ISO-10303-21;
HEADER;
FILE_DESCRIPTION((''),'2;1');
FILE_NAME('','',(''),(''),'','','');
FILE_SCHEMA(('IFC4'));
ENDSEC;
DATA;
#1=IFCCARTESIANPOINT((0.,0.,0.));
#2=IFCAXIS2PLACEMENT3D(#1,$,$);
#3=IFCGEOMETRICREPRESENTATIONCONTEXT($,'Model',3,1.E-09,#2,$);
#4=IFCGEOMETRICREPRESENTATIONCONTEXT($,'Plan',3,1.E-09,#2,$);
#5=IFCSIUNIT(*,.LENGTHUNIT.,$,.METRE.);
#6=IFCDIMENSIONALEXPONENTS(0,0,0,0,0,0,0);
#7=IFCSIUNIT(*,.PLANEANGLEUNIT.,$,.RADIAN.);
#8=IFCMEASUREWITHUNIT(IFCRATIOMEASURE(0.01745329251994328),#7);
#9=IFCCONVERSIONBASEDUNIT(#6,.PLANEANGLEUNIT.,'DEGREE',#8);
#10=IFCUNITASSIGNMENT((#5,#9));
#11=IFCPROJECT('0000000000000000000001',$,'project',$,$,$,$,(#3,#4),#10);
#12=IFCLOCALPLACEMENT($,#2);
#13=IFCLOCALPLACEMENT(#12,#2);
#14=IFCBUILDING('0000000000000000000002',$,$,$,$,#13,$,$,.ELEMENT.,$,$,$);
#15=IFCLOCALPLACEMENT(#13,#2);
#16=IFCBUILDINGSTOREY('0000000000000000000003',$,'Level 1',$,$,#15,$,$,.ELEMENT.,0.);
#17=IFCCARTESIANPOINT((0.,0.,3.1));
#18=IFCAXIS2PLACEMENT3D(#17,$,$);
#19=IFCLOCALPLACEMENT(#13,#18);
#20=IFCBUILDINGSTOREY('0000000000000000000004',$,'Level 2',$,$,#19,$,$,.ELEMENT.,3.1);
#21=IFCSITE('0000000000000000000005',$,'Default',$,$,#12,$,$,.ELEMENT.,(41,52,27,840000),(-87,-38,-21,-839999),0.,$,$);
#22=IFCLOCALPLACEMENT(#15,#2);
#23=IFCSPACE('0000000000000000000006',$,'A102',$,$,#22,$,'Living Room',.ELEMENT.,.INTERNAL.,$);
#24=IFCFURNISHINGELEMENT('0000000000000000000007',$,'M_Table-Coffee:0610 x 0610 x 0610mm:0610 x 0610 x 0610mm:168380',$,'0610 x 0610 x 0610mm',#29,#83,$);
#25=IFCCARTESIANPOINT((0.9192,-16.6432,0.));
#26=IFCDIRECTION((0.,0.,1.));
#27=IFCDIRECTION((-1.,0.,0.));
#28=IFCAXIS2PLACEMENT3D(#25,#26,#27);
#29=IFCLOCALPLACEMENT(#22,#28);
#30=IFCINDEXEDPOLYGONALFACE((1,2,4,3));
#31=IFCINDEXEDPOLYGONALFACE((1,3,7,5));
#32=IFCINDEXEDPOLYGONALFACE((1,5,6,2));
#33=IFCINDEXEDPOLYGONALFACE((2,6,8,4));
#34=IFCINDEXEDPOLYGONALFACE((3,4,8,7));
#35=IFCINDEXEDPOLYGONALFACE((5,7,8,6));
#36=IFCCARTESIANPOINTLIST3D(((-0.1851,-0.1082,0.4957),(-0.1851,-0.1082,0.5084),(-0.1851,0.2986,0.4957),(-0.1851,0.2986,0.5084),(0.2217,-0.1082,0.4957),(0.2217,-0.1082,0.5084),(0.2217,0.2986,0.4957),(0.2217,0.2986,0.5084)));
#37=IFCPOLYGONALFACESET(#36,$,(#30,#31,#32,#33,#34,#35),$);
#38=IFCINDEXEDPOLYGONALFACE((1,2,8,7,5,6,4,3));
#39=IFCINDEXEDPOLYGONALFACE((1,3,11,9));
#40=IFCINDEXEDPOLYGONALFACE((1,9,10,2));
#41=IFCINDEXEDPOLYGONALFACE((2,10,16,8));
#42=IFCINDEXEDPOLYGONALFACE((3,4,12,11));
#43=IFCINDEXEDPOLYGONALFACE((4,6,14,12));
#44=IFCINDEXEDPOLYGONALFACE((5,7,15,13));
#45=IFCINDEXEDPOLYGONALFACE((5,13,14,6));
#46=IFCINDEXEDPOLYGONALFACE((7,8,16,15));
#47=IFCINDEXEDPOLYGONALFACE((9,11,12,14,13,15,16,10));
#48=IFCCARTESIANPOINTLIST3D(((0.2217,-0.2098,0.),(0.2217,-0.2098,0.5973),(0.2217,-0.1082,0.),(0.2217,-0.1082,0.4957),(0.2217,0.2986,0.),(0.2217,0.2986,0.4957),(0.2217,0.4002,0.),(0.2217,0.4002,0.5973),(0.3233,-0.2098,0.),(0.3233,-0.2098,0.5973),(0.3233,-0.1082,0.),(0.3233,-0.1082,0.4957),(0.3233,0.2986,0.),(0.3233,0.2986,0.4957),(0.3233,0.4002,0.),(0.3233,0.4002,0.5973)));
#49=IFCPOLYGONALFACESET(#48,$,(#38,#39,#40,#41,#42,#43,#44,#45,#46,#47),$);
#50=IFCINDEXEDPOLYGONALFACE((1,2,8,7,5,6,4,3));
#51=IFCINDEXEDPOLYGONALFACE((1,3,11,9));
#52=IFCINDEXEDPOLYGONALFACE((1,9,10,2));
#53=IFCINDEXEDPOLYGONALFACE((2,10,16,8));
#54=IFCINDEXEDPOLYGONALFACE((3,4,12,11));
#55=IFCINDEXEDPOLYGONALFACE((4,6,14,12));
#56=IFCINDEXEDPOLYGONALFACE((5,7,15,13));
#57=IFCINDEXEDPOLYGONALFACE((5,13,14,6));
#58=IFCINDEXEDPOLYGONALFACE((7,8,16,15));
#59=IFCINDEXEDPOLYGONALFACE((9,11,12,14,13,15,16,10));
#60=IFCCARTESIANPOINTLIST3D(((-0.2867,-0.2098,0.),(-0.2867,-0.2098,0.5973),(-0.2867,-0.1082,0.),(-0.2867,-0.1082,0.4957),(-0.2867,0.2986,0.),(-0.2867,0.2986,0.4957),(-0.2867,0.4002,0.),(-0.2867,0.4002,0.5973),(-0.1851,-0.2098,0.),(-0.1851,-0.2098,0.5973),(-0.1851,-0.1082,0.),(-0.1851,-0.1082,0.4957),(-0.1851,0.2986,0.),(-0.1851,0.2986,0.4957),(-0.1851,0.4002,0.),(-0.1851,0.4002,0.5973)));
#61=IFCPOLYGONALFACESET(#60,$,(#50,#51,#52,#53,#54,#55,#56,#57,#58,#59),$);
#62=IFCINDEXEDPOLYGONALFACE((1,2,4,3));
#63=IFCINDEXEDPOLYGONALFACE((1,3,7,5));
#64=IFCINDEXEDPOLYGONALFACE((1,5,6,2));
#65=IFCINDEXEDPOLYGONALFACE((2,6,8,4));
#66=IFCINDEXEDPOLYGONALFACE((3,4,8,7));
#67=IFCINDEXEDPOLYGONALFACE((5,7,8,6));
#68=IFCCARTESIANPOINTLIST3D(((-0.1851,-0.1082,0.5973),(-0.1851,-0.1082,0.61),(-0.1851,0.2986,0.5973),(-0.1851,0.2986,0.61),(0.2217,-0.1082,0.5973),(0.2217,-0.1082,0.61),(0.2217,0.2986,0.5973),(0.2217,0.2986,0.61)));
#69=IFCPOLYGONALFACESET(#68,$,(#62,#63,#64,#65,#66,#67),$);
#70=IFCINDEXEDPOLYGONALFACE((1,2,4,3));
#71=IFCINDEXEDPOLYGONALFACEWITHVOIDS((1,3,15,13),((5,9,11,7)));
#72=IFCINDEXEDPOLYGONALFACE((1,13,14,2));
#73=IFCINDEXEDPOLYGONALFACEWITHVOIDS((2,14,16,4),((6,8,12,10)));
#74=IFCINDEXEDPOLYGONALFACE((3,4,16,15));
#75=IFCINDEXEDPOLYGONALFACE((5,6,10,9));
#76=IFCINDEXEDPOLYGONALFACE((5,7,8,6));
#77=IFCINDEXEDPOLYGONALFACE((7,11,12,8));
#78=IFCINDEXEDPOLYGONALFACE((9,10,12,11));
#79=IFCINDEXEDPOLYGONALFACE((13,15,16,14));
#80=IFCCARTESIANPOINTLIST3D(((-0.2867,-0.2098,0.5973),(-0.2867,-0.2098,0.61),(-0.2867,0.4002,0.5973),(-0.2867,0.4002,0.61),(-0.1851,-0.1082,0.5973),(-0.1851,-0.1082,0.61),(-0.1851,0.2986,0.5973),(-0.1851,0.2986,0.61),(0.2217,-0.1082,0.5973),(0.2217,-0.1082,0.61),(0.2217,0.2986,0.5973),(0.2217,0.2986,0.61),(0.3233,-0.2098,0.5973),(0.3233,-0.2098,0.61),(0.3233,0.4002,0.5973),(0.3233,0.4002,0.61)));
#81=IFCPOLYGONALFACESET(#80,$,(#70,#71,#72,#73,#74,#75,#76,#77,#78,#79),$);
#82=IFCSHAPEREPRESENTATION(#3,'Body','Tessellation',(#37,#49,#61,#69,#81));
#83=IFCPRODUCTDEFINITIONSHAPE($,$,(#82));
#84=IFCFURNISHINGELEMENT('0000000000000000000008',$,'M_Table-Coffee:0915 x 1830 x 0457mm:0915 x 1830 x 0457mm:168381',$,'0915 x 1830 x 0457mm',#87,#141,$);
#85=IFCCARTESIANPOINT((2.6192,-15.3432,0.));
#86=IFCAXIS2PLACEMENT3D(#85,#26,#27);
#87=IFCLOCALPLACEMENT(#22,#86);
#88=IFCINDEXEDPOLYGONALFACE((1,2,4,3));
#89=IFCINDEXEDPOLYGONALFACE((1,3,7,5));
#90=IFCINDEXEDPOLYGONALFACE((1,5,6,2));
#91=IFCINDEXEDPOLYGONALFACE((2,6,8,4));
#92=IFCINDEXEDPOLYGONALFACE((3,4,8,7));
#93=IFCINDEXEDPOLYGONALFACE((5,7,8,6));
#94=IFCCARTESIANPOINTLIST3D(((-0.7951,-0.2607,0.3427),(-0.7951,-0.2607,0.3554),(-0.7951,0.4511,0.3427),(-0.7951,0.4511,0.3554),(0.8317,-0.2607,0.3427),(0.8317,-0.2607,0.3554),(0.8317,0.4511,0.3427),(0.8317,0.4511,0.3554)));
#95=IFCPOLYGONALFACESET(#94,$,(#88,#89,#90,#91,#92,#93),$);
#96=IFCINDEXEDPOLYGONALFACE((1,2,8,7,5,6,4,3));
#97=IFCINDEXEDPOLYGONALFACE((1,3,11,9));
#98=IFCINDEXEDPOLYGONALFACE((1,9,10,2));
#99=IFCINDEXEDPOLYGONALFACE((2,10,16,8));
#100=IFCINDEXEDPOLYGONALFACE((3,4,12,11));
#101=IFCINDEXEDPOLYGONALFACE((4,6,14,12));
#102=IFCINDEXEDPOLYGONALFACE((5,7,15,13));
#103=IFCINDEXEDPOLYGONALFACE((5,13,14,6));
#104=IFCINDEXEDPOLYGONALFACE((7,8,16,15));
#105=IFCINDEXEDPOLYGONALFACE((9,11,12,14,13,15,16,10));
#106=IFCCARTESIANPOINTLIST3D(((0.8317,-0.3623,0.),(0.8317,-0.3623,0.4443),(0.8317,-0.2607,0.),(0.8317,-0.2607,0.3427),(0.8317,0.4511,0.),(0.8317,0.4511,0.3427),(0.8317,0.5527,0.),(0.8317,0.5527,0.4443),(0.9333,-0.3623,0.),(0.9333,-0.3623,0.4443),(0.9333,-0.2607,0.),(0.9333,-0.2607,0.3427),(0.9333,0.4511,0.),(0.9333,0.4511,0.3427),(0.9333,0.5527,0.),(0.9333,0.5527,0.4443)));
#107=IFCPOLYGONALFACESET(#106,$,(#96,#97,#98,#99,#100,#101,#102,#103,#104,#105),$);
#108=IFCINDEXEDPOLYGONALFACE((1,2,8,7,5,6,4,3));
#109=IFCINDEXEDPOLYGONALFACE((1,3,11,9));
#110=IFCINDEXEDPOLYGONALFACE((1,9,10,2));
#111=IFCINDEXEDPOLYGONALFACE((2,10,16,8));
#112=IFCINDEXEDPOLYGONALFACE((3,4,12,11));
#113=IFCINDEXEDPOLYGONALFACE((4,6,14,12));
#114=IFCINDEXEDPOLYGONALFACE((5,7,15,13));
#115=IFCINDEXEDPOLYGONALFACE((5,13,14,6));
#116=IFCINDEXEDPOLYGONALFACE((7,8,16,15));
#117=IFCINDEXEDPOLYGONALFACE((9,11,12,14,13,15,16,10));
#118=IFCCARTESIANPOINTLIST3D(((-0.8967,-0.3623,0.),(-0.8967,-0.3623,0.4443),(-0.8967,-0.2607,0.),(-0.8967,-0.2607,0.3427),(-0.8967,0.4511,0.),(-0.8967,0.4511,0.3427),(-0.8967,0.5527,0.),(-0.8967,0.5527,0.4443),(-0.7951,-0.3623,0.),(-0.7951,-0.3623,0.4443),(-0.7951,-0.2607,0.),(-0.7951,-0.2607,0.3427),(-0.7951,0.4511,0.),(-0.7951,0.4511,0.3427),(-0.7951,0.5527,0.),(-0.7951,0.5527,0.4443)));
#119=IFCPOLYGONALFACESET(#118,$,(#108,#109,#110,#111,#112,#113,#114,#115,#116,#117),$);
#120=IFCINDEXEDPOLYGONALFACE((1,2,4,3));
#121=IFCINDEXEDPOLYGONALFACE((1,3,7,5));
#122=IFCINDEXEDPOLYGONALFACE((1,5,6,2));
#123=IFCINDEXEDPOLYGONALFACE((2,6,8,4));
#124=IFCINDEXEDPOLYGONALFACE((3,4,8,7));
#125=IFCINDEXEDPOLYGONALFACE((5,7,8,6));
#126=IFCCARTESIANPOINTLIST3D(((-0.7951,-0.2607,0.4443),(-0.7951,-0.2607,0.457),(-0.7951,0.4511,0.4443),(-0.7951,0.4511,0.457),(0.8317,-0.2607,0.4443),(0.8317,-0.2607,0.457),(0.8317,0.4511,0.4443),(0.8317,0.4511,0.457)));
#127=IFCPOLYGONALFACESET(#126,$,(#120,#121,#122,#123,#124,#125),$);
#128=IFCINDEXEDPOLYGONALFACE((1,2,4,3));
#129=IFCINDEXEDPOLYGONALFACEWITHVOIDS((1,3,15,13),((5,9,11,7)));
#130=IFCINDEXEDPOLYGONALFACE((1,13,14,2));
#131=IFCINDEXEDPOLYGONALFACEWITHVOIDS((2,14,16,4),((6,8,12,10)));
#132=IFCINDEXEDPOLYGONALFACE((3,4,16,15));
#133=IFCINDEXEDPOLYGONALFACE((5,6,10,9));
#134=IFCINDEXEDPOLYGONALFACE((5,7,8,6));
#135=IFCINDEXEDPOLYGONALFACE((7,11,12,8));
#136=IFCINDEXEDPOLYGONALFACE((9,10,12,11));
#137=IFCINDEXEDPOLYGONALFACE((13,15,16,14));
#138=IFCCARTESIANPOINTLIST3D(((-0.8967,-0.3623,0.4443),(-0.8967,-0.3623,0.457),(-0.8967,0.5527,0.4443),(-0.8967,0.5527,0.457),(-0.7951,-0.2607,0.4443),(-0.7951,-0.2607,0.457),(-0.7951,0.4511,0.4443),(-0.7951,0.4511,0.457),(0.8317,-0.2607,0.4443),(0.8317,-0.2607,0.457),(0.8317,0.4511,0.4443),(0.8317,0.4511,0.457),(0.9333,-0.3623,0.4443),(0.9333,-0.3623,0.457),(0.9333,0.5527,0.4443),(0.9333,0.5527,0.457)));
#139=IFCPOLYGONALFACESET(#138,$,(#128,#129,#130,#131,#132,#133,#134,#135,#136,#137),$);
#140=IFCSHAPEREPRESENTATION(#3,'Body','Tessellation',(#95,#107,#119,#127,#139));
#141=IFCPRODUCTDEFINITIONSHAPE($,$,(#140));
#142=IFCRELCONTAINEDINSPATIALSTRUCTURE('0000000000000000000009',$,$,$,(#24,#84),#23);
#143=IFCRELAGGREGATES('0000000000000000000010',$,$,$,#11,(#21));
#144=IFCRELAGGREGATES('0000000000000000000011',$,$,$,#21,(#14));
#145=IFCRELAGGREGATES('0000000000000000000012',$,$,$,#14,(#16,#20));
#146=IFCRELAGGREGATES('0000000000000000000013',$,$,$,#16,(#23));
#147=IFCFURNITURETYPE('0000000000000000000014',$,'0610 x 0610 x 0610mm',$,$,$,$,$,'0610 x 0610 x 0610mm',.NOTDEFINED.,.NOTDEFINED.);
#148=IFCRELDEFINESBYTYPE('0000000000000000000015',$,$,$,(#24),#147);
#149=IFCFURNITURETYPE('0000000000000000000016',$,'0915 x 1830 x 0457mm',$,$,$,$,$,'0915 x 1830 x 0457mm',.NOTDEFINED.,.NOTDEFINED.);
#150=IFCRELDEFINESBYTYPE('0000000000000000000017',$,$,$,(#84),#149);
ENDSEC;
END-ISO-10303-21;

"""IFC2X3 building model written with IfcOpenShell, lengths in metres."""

from ifc_helpers import new_model, entity, si_unit, converted_unit, frame, origin, origin_2d_with_axis, place, context, project, spatial, polyline, rectangle, outline, extrude, source, transform, mapped, type_object, type_shapes, element, save


model = new_model("IFC2X3")

# Units and contexts
model_context = context("Model", 3, precision=1e-09, world=origin())
plan_context = context("Plan", 3, precision=1e-09, world=origin())
ifc_project = project(units=[si_unit("LENGTHUNIT", "METRE"), converted_unit("PLANEANGLEUNIT", "DEGREE", entity("IfcRatioMeasure", 0.01745329251994328), si_unit("PLANEANGLEUNIT", "RADIAN"), dimensions=[0, 0, 0, 0, 0, 0, 0])], contexts=[model_context, plan_context])

# Site, building, storey
site_placement = place(None, origin())
site = spatial("IfcSite", under=ifc_project, at=site_placement, Name="Default", CompositionType="ELEMENT", RefLatitude=(41, 52, 27, 840000), RefLongitude=(-87, -38, -21, -839999), RefElevation=0.0)
building_placement = place(site_placement, origin())
building = spatial("IfcBuilding", under=site, at=building_placement, CompositionType="ELEMENT")
storey_1_placement = place(building_placement, origin())
storey_1 = spatial("IfcBuildingStorey", under=building, at=storey_1_placement, Name="Level 1", CompositionType="ELEMENT", Elevation=0.0)

# Shared definitions
storey_2_placement = place(building_placement, frame((0.0, 0.0, 3.1)))
storey_2 = spatial("IfcBuildingStorey", under=building, at=storey_2_placement, Name="Level 2", CompositionType="ELEMENT", Elevation=3.1)

# Shared definitions
space_1_placement = place(storey_1_placement, origin())
space_1 = spatial("IfcSpace", under=storey_1, at=space_1_placement, Name="A102", LongName="Living Room", CompositionType="ELEMENT", InteriorOrExteriorSpace="INTERNAL")

# Furnishing element
furniture_type_1 = type_object("IfcFurnitureType", Name="0610 x 0610 x 0610mm", ElementType="0610 x 0610 x 0610mm", AssemblyPlace="NOTDEFINED")
shared_shape_1 = source(origin(), model_context, "Body", "SweptSolid", [
    extrude(rectangle(XDim=0.4068, YDim=0.4068, at=origin_2d_with_axis()), frame((0.0183, 0.0952, 0.4957), z_axis=(0.0, 0.0, 1.0), x_axis=(-1.0, 0.0, 0.0)), (0.0, 0.0, 1.0), 0.0127),
    extrude(outline(polyline([(-0.2732, -0.305), (0.324, -0.305), (0.324, 0.305), (-0.2732, 0.305), (-0.2732, 0.2034), (0.2225, 0.2034), (0.2225, -0.2034), (-0.2732, -0.2034), (-0.2732, -0.305)])), frame((0.2217, 0.0952, 0.2732), z_axis=(1.0, 0.0, 0.0), x_axis=(0.0, 0.0, 1.0)), (0.0, 0.0, 1.0), 0.1016),
    extrude(outline(polyline([(-0.305, -0.3241), (0.305, -0.3241), (0.305, 0.2733), (0.2034, 0.2733), (0.2034, -0.2224), (-0.2034, -0.2224), (-0.2034, 0.2733), (-0.305, 0.2733), (-0.305, -0.3241)])), frame((-0.2867, 0.0952, 0.2733), z_axis=(1.0, 0.0, 0.0), x_axis=(0.0, -1.0, 0.0)), (0.0, 0.0, 1.0), 0.1016),
    extrude(rectangle(XDim=0.4068, YDim=0.4068, at=origin_2d_with_axis()), frame((0.0183, 0.0952, 0.5973), z_axis=(0.0, 0.0, 1.0), x_axis=(-1.0, 0.0, 0.0)), (0.0, 0.0, 1.0), 0.0127),
    extrude(outline(polyline([(-0.305, -0.305), (0.305, -0.305), (0.305, 0.305), (-0.305, 0.305), (-0.305, -0.305)]), holes=[polyline([(-0.2034, -0.2034), (-0.2034, 0.2034), (0.2034, 0.2034), (0.2034, -0.2034), (-0.2034, -0.2034)])]), frame((0.0183, 0.0952, 0.5973), z_axis=(0.0, 0.0, 1.0), x_axis=(-1.0, 0.0, 0.0)), (0.0, 0.0, 1.0), 0.0127),
])
type_shapes(furniture_type_1, [shared_shape_1])
for number, where, z_axis, x_axis, name in (
    (1, (0.9192, -16.6432, 0.0), (0.0, 0.0, 1.0), (-1.0, 0.0, 0.0), "M_Table-Coffee:0610 x 0610 x 0610mm:0610 x 0610 x 0610mm:168380"),
):
    element("IfcFurnishingElement", number, at=place(space_1_placement, frame(where, z_axis=z_axis, x_axis=x_axis)), inside=space_1, type_object=furniture_type_1, Name=name, ObjectType="0610 x 0610 x 0610mm", context=model_context, shape_type="MappedRepresentation", body=[
        mapped(shared_shape_1, transform((0.0, 0.0, 0.0), scale=1.0)),
    ])

# Furnishing element
furniture_type_2 = type_object("IfcFurnitureType", Name="0915 x 1830 x 0457mm", ElementType="0915 x 1830 x 0457mm", AssemblyPlace="NOTDEFINED")
shared_shape_2 = source(origin(), model_context, "Body", "SweptSolid", [
    extrude(rectangle(XDim=1.6268, YDim=0.7118, at=origin_2d_with_axis()), frame((0.0183, 0.0952, 0.3427), z_axis=(0.0, 0.0, 1.0), x_axis=(-1.0, 0.0, 0.0)), (0.0, 0.0, 1.0), 0.0127),
    extrude(outline(polyline([(-0.1967, -0.4575), (0.2475, -0.4575), (0.2475, 0.4575), (-0.1967, 0.4575), (-0.1967, 0.3559), (0.146, 0.3559), (0.146, -0.3559), (-0.1967, -0.3559), (-0.1967, -0.4575)])), frame((0.8317, 0.0952, 0.1967), z_axis=(1.0, 0.0, 0.0), x_axis=(0.0, 0.0, 1.0)), (0.0, 0.0, 1.0), 0.1016),
    extrude(outline(polyline([(-0.4575, -0.2476), (0.4575, -0.2476), (0.4575, 0.1968), (0.3559, 0.1968), (0.3559, -0.1459), (-0.3559, -0.1459), (-0.3559, 0.1968), (-0.4575, 0.1968), (-0.4575, -0.2476)])), frame((-0.8967, 0.0952, 0.1968), z_axis=(1.0, 0.0, 0.0), x_axis=(0.0, -1.0, 0.0)), (0.0, 0.0, 1.0), 0.1016),
    extrude(rectangle(XDim=1.6268, YDim=0.7118, at=origin_2d_with_axis()), frame((0.0183, 0.0952, 0.4443), z_axis=(0.0, 0.0, 1.0), x_axis=(-1.0, 0.0, 0.0)), (0.0, 0.0, 1.0), 0.0127),
    extrude(outline(polyline([(-0.915, -0.4575), (0.915, -0.4575), (0.915, 0.4575), (-0.915, 0.4575), (-0.915, -0.4575)]), holes=[polyline([(-0.8134, -0.3559), (-0.8134, 0.3559), (0.8134, 0.3559), (0.8134, -0.3559), (-0.8134, -0.3559)])]), frame((0.0183, 0.0952, 0.4443), z_axis=(0.0, 0.0, 1.0), x_axis=(-1.0, 0.0, 0.0)), (0.0, 0.0, 1.0), 0.0127),
])
type_shapes(furniture_type_2, [shared_shape_2])
furnishing_1_placement = place(space_1_placement, frame((2.6192, -15.3432, 0.0), z_axis=(0.0, 0.0, 1.0), x_axis=(-1.0, 0.0, 0.0)))
element("IfcFurnishingElement", 2, at=furnishing_1_placement, inside=space_1, type_object=furniture_type_2, Name="M_Table-Coffee:0915 x 1830 x 0457mm:0915 x 1830 x 0457mm:168381", ObjectType="0915 x 1830 x 0457mm", context=model_context, shape_type="MappedRepresentation", body=[
    mapped(shared_shape_2, transform((0.0, 0.0, 0.0), scale=1.0)),
])

save(model, "model.ifc")
